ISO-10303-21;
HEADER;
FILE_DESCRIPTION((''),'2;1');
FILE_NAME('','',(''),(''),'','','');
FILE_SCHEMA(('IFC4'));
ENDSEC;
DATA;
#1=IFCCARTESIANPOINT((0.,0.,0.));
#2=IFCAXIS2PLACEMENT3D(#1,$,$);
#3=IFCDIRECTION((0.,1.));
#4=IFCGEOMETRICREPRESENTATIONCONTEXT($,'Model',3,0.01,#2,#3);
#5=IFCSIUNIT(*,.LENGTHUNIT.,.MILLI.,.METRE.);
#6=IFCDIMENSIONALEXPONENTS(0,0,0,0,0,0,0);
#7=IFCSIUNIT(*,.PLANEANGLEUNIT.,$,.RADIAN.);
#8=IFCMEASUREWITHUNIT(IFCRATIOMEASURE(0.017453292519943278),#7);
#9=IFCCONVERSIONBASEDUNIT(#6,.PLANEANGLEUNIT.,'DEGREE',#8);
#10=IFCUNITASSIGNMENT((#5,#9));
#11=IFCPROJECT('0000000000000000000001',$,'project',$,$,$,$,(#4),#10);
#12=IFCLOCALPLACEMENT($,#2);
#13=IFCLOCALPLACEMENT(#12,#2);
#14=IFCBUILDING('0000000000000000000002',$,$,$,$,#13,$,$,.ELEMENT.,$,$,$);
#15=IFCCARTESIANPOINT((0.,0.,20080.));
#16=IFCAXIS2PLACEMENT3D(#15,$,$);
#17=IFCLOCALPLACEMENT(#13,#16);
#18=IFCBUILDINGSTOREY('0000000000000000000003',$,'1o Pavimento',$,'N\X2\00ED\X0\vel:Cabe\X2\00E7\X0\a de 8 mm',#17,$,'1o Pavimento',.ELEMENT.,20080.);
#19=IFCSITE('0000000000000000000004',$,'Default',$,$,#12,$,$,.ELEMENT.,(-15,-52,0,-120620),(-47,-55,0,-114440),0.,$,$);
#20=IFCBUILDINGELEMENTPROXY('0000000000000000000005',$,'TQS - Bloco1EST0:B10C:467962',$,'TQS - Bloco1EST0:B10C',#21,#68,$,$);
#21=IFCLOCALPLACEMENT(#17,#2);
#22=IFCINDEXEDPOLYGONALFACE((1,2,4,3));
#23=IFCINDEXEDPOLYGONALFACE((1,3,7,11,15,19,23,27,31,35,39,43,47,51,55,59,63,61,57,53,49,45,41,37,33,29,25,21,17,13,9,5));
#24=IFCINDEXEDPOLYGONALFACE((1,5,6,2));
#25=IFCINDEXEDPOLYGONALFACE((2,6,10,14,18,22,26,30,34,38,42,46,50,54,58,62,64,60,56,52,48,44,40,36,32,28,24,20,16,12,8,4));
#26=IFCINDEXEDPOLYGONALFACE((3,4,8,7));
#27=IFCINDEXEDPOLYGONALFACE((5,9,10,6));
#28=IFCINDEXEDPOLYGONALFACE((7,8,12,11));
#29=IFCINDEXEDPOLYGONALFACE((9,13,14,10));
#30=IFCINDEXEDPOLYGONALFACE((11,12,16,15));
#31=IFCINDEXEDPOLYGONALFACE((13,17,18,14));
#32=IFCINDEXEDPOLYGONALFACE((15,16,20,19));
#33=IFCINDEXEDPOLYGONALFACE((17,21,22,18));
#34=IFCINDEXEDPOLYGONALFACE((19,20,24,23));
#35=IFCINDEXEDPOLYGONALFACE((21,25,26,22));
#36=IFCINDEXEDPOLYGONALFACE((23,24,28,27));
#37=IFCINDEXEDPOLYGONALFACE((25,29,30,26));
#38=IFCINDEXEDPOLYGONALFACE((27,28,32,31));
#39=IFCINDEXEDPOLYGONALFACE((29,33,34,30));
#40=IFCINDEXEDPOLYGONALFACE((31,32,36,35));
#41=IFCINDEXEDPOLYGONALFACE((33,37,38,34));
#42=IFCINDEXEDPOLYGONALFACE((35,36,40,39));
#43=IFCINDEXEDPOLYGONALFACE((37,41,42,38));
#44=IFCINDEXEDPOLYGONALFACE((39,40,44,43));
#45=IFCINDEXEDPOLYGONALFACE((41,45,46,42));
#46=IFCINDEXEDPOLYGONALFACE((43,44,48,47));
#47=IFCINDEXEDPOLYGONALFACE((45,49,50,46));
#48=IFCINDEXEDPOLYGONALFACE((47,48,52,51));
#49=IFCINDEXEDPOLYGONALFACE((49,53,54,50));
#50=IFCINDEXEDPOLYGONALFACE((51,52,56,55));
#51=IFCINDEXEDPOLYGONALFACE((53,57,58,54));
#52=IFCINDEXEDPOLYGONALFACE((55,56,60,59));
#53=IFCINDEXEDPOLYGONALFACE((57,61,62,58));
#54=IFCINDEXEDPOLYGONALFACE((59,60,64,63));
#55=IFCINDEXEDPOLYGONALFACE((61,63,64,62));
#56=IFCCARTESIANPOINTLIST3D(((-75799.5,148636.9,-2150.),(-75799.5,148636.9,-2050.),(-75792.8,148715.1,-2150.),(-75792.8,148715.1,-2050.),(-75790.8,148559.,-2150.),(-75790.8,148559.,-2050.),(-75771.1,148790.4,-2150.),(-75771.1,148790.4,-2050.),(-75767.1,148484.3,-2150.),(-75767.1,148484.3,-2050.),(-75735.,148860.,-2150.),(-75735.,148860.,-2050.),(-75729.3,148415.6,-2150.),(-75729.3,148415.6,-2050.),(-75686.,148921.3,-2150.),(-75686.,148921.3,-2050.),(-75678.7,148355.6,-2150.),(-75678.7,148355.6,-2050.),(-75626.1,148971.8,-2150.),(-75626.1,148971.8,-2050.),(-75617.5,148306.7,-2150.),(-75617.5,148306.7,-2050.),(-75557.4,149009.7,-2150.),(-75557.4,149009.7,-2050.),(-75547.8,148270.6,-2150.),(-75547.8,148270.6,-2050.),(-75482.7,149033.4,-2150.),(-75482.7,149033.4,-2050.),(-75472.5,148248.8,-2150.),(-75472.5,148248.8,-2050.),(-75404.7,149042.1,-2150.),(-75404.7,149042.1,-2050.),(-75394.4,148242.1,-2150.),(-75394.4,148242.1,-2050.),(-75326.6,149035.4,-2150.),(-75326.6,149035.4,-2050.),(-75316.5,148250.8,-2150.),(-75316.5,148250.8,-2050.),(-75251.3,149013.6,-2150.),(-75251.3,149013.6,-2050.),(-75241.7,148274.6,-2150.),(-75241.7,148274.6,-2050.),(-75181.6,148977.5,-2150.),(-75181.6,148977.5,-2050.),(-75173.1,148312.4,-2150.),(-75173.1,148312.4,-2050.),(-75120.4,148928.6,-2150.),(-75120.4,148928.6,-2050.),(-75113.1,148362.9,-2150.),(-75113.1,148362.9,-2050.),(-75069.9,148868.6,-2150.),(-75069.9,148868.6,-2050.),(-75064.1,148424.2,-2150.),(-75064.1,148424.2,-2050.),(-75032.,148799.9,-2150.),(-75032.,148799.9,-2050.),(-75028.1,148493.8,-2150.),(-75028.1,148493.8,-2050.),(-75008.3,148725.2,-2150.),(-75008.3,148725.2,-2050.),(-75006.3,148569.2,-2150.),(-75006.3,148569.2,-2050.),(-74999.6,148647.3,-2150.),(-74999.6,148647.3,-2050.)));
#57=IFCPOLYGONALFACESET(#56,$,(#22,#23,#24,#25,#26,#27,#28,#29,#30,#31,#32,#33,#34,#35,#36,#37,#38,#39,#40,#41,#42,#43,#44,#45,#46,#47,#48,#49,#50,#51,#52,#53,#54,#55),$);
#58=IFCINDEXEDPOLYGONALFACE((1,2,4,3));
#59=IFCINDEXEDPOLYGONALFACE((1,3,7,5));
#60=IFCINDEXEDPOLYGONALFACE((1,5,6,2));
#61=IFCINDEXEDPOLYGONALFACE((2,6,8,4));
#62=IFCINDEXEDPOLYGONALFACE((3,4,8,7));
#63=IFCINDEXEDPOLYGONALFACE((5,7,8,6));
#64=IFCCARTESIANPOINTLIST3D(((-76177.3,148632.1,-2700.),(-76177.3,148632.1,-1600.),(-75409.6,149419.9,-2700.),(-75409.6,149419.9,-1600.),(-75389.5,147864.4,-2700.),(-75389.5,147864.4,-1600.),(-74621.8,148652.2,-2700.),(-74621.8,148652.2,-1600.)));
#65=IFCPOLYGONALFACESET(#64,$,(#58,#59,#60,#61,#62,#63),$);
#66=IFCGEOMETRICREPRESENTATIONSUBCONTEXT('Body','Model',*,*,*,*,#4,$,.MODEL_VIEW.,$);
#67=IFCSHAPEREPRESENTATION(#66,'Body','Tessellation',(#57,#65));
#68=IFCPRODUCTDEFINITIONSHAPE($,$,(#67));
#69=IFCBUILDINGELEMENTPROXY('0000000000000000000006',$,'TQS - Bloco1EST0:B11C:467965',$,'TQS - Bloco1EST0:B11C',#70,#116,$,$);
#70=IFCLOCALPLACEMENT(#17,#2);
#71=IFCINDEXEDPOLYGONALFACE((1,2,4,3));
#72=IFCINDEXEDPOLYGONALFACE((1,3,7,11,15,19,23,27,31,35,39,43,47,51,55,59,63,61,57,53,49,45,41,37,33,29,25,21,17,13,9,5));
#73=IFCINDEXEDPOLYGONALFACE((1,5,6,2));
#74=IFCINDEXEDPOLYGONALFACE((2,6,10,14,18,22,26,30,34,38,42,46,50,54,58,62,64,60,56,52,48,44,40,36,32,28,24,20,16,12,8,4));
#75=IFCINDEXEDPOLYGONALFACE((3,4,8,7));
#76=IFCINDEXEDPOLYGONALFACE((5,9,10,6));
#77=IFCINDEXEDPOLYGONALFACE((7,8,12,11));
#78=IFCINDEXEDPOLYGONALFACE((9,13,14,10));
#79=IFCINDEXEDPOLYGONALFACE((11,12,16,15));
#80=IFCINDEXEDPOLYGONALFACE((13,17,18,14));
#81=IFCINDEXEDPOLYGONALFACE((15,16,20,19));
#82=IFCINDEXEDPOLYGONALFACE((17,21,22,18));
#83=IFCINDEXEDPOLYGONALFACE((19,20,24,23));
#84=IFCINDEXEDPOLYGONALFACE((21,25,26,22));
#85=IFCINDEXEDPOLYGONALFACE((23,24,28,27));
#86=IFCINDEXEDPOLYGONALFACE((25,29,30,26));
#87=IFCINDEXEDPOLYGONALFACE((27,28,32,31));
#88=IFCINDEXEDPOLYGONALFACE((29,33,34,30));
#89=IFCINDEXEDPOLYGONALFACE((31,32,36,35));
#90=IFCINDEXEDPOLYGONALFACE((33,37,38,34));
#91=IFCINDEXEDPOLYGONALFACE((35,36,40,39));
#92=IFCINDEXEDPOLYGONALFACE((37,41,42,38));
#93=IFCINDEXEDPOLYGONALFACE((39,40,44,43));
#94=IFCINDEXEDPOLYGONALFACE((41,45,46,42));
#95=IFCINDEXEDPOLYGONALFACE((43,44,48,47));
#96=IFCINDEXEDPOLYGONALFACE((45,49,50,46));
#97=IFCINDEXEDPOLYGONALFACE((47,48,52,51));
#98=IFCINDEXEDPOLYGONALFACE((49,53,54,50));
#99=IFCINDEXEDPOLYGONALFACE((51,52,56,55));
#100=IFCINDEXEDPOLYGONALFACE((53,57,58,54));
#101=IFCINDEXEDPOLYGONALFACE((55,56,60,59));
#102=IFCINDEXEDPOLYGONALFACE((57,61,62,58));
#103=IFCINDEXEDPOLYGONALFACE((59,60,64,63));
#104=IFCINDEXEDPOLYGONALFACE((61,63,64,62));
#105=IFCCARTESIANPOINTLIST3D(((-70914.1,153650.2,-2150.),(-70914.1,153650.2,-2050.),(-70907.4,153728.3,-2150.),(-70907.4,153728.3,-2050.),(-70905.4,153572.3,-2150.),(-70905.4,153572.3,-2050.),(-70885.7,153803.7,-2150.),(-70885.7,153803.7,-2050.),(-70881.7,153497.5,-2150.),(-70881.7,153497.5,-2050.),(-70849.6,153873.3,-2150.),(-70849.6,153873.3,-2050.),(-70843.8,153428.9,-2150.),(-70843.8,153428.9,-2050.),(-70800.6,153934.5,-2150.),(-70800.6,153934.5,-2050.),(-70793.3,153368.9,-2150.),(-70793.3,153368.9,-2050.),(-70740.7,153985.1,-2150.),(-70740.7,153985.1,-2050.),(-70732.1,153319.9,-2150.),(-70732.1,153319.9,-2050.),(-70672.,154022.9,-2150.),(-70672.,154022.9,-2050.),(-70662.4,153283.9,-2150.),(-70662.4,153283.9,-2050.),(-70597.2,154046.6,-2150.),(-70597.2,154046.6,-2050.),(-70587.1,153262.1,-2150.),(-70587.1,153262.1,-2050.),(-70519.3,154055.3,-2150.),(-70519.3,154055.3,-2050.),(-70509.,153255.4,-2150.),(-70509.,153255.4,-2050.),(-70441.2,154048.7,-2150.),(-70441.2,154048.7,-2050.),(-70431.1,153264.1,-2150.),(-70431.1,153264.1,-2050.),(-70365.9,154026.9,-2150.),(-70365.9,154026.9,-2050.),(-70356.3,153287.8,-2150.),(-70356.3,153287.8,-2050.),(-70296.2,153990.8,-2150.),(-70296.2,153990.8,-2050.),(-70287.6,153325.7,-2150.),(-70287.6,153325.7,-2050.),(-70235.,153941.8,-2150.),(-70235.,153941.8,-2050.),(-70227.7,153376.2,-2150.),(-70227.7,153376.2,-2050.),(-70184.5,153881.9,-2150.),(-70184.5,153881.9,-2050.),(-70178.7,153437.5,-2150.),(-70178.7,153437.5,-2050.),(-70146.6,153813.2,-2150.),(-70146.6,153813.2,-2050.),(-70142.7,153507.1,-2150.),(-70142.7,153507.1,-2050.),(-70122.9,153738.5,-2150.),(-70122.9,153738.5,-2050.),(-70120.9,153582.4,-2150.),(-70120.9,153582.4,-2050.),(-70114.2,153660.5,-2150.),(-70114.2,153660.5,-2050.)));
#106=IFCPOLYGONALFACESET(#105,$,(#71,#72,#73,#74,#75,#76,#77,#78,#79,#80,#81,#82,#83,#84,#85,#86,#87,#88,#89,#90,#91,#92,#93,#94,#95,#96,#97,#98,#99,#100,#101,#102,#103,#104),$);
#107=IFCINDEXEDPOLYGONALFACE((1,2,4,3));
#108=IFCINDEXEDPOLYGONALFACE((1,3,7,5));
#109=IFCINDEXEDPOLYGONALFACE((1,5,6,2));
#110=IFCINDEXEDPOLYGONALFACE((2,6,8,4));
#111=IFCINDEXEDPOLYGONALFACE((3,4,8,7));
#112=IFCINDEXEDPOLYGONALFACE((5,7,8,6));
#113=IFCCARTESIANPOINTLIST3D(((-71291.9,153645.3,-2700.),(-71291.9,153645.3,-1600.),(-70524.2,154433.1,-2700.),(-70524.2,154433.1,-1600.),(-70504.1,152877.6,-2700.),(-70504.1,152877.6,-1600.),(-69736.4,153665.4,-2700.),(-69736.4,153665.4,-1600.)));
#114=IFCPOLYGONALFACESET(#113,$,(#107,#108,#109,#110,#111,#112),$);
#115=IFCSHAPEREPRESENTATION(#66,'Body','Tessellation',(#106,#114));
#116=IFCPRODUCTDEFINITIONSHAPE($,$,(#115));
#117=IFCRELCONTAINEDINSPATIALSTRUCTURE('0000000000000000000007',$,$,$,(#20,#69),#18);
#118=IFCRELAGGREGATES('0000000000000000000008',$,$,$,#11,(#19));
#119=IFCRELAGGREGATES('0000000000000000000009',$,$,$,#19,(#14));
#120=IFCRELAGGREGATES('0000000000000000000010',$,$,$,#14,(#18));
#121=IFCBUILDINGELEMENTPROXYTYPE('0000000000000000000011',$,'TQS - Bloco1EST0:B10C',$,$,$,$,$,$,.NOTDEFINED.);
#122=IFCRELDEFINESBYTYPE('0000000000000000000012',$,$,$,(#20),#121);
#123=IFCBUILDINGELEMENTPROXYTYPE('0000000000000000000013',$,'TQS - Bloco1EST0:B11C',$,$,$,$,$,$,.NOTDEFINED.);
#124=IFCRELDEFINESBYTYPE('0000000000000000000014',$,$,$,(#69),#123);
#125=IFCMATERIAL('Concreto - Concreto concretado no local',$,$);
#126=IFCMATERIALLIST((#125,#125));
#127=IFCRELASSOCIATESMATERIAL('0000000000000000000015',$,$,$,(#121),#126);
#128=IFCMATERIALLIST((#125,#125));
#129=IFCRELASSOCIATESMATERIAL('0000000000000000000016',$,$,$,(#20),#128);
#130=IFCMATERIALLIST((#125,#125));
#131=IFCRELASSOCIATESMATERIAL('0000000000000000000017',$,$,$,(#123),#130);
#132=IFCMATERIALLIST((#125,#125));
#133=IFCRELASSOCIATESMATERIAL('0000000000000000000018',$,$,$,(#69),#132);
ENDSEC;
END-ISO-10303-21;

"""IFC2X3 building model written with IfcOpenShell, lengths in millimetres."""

from ifc_helpers import new_model, entity, si_unit, converted_unit, direction, frame, frame_2d, origin, origin_2d_with_axis, place, context, subcontext, project, spatial, rectangle, circle, extrude, source, transform, mapped, material, material_list, type_object, type_shapes, element, save


model = new_model("IFC2X3")

# Units and contexts
model_context = context("Model", 3, precision=0.01, world=origin(), true_north=direction((0.0, 1.0)))
body_context = subcontext(model_context, "Body", "Model", "MODEL_VIEW")
ifc_project = project(units=[si_unit("LENGTHUNIT", "METRE", prefix="MILLI"), converted_unit("PLANEANGLEUNIT", "DEGREE", entity("IfcRatioMeasure", 0.017453292519943278), si_unit("PLANEANGLEUNIT", "RADIAN"), dimensions=[0, 0, 0, 0, 0, 0, 0])], contexts=[model_context])

# Site, building, storey
site_placement = place(None, origin())
site = spatial("IfcSite", under=ifc_project, at=site_placement, Name="Default", CompositionType="ELEMENT", RefLatitude=(-15, -52, 0, -120620), RefLongitude=(-47, -55, 0, -114440), RefElevation=0.0)
building_placement = place(site_placement, origin())
building = spatial("IfcBuilding", under=site, at=building_placement, CompositionType="ELEMENT")
storey_placement = place(building_placement, frame((0.0, 0.0, 20080.0)))
storey = spatial("IfcBuildingStorey", under=building, at=storey_placement, Name="1o Pavimento", ObjectType="Nível:Cabeça de 8 mm", LongName="1o Pavimento", CompositionType="ELEMENT", Elevation=20080.0)

# Building element proxies
ifc_material_1 = material(Name="Concreto - Concreto concretado no local")
ifc_material_list_1 = material_list([ifc_material_1, ifc_material_1])
ifc_material_list_2 = material_list([ifc_material_1, ifc_material_1])
building_element_proxy_type_1 = type_object("IfcBuildingElementProxyType", Name="TQS - Bloco1EST0:B10C", PredefinedType="NOTDEFINED", material=ifc_material_list_2)
shared_shape_1 = source(origin(), body_context, "Body", "SweptSolid", [
    extrude(circle(Radius=400.0, at=frame_2d((0.0, 0.0), x_axis=(1.0, 0.0))), frame((0.0, 0.0, -550.0)), (0.0, 0.0, 1.0), 100.0),
    extrude(rectangle(XDim=1100.0, YDim=1100.0, at=origin_2d_with_axis()), frame((0.0, 0.0, -1100.0), z_axis=(0.0, 0.0, 1.0), x_axis=(-1.0, 0.0, 0.0)), (0.0, 0.0, 1.0), 1100.0),
])
type_shapes(building_element_proxy_type_1, [shared_shape_1])
proxy_1_placement = place(storey_placement, frame((-75399.6, 148642.1, -1600.0), z_axis=(0.0, 0.0, 1.0), x_axis=(0.697915, 0.71618, 0.0)))
element("IfcBuildingElementProxy", 1, at=proxy_1_placement, inside=storey, type_object=building_element_proxy_type_1, material=ifc_material_list_1, Name="TQS - Bloco1EST0:B10C:467962", ObjectType="TQS - Bloco1EST0:B10C", context=body_context, shape_type="MappedRepresentation", body=[
    mapped(shared_shape_1, transform((0.0, 0.0, 0.0), scale=1.0)),
])
ifc_material_list_3 = material_list([ifc_material_1, ifc_material_1])
ifc_material_list_4 = material_list([ifc_material_1, ifc_material_1])
building_element_proxy_type_2 = type_object("IfcBuildingElementProxyType", Name="TQS - Bloco1EST0:B11C", PredefinedType="NOTDEFINED", material=ifc_material_list_4)
shared_shape_2 = source(origin(), body_context, "Body", "SweptSolid", [
    extrude(circle(Radius=400.0, at=frame_2d((0.0, 0.0), x_axis=(1.0, 0.0))), frame((0.0, 0.0, -550.0)), (0.0, 0.0, 1.0), 100.0),
    extrude(rectangle(XDim=1100.0, YDim=1100.0, at=origin_2d_with_axis()), frame((0.0, 0.0, -1100.0), z_axis=(0.0, 0.0, 1.0), x_axis=(-1.0, 0.0, 0.0)), (0.0, 0.0, 1.0), 1100.0),
])
type_shapes(building_element_proxy_type_2, [shared_shape_2])
proxy_2_placement = place(storey_placement, frame((-70514.2, 153655.4, -1600.0), z_axis=(0.0, 0.0, 1.0), x_axis=(0.697915, 0.71618, 0.0)))
element("IfcBuildingElementProxy", 2, at=proxy_2_placement, inside=storey, type_object=building_element_proxy_type_2, material=ifc_material_list_3, Name="TQS - Bloco1EST0:B11C:467965", ObjectType="TQS - Bloco1EST0:B11C", context=body_context, shape_type="MappedRepresentation", body=[
    mapped(shared_shape_2, transform((0.0, 0.0, 0.0), scale=1.0)),
])

save(model, "model.ifc")
